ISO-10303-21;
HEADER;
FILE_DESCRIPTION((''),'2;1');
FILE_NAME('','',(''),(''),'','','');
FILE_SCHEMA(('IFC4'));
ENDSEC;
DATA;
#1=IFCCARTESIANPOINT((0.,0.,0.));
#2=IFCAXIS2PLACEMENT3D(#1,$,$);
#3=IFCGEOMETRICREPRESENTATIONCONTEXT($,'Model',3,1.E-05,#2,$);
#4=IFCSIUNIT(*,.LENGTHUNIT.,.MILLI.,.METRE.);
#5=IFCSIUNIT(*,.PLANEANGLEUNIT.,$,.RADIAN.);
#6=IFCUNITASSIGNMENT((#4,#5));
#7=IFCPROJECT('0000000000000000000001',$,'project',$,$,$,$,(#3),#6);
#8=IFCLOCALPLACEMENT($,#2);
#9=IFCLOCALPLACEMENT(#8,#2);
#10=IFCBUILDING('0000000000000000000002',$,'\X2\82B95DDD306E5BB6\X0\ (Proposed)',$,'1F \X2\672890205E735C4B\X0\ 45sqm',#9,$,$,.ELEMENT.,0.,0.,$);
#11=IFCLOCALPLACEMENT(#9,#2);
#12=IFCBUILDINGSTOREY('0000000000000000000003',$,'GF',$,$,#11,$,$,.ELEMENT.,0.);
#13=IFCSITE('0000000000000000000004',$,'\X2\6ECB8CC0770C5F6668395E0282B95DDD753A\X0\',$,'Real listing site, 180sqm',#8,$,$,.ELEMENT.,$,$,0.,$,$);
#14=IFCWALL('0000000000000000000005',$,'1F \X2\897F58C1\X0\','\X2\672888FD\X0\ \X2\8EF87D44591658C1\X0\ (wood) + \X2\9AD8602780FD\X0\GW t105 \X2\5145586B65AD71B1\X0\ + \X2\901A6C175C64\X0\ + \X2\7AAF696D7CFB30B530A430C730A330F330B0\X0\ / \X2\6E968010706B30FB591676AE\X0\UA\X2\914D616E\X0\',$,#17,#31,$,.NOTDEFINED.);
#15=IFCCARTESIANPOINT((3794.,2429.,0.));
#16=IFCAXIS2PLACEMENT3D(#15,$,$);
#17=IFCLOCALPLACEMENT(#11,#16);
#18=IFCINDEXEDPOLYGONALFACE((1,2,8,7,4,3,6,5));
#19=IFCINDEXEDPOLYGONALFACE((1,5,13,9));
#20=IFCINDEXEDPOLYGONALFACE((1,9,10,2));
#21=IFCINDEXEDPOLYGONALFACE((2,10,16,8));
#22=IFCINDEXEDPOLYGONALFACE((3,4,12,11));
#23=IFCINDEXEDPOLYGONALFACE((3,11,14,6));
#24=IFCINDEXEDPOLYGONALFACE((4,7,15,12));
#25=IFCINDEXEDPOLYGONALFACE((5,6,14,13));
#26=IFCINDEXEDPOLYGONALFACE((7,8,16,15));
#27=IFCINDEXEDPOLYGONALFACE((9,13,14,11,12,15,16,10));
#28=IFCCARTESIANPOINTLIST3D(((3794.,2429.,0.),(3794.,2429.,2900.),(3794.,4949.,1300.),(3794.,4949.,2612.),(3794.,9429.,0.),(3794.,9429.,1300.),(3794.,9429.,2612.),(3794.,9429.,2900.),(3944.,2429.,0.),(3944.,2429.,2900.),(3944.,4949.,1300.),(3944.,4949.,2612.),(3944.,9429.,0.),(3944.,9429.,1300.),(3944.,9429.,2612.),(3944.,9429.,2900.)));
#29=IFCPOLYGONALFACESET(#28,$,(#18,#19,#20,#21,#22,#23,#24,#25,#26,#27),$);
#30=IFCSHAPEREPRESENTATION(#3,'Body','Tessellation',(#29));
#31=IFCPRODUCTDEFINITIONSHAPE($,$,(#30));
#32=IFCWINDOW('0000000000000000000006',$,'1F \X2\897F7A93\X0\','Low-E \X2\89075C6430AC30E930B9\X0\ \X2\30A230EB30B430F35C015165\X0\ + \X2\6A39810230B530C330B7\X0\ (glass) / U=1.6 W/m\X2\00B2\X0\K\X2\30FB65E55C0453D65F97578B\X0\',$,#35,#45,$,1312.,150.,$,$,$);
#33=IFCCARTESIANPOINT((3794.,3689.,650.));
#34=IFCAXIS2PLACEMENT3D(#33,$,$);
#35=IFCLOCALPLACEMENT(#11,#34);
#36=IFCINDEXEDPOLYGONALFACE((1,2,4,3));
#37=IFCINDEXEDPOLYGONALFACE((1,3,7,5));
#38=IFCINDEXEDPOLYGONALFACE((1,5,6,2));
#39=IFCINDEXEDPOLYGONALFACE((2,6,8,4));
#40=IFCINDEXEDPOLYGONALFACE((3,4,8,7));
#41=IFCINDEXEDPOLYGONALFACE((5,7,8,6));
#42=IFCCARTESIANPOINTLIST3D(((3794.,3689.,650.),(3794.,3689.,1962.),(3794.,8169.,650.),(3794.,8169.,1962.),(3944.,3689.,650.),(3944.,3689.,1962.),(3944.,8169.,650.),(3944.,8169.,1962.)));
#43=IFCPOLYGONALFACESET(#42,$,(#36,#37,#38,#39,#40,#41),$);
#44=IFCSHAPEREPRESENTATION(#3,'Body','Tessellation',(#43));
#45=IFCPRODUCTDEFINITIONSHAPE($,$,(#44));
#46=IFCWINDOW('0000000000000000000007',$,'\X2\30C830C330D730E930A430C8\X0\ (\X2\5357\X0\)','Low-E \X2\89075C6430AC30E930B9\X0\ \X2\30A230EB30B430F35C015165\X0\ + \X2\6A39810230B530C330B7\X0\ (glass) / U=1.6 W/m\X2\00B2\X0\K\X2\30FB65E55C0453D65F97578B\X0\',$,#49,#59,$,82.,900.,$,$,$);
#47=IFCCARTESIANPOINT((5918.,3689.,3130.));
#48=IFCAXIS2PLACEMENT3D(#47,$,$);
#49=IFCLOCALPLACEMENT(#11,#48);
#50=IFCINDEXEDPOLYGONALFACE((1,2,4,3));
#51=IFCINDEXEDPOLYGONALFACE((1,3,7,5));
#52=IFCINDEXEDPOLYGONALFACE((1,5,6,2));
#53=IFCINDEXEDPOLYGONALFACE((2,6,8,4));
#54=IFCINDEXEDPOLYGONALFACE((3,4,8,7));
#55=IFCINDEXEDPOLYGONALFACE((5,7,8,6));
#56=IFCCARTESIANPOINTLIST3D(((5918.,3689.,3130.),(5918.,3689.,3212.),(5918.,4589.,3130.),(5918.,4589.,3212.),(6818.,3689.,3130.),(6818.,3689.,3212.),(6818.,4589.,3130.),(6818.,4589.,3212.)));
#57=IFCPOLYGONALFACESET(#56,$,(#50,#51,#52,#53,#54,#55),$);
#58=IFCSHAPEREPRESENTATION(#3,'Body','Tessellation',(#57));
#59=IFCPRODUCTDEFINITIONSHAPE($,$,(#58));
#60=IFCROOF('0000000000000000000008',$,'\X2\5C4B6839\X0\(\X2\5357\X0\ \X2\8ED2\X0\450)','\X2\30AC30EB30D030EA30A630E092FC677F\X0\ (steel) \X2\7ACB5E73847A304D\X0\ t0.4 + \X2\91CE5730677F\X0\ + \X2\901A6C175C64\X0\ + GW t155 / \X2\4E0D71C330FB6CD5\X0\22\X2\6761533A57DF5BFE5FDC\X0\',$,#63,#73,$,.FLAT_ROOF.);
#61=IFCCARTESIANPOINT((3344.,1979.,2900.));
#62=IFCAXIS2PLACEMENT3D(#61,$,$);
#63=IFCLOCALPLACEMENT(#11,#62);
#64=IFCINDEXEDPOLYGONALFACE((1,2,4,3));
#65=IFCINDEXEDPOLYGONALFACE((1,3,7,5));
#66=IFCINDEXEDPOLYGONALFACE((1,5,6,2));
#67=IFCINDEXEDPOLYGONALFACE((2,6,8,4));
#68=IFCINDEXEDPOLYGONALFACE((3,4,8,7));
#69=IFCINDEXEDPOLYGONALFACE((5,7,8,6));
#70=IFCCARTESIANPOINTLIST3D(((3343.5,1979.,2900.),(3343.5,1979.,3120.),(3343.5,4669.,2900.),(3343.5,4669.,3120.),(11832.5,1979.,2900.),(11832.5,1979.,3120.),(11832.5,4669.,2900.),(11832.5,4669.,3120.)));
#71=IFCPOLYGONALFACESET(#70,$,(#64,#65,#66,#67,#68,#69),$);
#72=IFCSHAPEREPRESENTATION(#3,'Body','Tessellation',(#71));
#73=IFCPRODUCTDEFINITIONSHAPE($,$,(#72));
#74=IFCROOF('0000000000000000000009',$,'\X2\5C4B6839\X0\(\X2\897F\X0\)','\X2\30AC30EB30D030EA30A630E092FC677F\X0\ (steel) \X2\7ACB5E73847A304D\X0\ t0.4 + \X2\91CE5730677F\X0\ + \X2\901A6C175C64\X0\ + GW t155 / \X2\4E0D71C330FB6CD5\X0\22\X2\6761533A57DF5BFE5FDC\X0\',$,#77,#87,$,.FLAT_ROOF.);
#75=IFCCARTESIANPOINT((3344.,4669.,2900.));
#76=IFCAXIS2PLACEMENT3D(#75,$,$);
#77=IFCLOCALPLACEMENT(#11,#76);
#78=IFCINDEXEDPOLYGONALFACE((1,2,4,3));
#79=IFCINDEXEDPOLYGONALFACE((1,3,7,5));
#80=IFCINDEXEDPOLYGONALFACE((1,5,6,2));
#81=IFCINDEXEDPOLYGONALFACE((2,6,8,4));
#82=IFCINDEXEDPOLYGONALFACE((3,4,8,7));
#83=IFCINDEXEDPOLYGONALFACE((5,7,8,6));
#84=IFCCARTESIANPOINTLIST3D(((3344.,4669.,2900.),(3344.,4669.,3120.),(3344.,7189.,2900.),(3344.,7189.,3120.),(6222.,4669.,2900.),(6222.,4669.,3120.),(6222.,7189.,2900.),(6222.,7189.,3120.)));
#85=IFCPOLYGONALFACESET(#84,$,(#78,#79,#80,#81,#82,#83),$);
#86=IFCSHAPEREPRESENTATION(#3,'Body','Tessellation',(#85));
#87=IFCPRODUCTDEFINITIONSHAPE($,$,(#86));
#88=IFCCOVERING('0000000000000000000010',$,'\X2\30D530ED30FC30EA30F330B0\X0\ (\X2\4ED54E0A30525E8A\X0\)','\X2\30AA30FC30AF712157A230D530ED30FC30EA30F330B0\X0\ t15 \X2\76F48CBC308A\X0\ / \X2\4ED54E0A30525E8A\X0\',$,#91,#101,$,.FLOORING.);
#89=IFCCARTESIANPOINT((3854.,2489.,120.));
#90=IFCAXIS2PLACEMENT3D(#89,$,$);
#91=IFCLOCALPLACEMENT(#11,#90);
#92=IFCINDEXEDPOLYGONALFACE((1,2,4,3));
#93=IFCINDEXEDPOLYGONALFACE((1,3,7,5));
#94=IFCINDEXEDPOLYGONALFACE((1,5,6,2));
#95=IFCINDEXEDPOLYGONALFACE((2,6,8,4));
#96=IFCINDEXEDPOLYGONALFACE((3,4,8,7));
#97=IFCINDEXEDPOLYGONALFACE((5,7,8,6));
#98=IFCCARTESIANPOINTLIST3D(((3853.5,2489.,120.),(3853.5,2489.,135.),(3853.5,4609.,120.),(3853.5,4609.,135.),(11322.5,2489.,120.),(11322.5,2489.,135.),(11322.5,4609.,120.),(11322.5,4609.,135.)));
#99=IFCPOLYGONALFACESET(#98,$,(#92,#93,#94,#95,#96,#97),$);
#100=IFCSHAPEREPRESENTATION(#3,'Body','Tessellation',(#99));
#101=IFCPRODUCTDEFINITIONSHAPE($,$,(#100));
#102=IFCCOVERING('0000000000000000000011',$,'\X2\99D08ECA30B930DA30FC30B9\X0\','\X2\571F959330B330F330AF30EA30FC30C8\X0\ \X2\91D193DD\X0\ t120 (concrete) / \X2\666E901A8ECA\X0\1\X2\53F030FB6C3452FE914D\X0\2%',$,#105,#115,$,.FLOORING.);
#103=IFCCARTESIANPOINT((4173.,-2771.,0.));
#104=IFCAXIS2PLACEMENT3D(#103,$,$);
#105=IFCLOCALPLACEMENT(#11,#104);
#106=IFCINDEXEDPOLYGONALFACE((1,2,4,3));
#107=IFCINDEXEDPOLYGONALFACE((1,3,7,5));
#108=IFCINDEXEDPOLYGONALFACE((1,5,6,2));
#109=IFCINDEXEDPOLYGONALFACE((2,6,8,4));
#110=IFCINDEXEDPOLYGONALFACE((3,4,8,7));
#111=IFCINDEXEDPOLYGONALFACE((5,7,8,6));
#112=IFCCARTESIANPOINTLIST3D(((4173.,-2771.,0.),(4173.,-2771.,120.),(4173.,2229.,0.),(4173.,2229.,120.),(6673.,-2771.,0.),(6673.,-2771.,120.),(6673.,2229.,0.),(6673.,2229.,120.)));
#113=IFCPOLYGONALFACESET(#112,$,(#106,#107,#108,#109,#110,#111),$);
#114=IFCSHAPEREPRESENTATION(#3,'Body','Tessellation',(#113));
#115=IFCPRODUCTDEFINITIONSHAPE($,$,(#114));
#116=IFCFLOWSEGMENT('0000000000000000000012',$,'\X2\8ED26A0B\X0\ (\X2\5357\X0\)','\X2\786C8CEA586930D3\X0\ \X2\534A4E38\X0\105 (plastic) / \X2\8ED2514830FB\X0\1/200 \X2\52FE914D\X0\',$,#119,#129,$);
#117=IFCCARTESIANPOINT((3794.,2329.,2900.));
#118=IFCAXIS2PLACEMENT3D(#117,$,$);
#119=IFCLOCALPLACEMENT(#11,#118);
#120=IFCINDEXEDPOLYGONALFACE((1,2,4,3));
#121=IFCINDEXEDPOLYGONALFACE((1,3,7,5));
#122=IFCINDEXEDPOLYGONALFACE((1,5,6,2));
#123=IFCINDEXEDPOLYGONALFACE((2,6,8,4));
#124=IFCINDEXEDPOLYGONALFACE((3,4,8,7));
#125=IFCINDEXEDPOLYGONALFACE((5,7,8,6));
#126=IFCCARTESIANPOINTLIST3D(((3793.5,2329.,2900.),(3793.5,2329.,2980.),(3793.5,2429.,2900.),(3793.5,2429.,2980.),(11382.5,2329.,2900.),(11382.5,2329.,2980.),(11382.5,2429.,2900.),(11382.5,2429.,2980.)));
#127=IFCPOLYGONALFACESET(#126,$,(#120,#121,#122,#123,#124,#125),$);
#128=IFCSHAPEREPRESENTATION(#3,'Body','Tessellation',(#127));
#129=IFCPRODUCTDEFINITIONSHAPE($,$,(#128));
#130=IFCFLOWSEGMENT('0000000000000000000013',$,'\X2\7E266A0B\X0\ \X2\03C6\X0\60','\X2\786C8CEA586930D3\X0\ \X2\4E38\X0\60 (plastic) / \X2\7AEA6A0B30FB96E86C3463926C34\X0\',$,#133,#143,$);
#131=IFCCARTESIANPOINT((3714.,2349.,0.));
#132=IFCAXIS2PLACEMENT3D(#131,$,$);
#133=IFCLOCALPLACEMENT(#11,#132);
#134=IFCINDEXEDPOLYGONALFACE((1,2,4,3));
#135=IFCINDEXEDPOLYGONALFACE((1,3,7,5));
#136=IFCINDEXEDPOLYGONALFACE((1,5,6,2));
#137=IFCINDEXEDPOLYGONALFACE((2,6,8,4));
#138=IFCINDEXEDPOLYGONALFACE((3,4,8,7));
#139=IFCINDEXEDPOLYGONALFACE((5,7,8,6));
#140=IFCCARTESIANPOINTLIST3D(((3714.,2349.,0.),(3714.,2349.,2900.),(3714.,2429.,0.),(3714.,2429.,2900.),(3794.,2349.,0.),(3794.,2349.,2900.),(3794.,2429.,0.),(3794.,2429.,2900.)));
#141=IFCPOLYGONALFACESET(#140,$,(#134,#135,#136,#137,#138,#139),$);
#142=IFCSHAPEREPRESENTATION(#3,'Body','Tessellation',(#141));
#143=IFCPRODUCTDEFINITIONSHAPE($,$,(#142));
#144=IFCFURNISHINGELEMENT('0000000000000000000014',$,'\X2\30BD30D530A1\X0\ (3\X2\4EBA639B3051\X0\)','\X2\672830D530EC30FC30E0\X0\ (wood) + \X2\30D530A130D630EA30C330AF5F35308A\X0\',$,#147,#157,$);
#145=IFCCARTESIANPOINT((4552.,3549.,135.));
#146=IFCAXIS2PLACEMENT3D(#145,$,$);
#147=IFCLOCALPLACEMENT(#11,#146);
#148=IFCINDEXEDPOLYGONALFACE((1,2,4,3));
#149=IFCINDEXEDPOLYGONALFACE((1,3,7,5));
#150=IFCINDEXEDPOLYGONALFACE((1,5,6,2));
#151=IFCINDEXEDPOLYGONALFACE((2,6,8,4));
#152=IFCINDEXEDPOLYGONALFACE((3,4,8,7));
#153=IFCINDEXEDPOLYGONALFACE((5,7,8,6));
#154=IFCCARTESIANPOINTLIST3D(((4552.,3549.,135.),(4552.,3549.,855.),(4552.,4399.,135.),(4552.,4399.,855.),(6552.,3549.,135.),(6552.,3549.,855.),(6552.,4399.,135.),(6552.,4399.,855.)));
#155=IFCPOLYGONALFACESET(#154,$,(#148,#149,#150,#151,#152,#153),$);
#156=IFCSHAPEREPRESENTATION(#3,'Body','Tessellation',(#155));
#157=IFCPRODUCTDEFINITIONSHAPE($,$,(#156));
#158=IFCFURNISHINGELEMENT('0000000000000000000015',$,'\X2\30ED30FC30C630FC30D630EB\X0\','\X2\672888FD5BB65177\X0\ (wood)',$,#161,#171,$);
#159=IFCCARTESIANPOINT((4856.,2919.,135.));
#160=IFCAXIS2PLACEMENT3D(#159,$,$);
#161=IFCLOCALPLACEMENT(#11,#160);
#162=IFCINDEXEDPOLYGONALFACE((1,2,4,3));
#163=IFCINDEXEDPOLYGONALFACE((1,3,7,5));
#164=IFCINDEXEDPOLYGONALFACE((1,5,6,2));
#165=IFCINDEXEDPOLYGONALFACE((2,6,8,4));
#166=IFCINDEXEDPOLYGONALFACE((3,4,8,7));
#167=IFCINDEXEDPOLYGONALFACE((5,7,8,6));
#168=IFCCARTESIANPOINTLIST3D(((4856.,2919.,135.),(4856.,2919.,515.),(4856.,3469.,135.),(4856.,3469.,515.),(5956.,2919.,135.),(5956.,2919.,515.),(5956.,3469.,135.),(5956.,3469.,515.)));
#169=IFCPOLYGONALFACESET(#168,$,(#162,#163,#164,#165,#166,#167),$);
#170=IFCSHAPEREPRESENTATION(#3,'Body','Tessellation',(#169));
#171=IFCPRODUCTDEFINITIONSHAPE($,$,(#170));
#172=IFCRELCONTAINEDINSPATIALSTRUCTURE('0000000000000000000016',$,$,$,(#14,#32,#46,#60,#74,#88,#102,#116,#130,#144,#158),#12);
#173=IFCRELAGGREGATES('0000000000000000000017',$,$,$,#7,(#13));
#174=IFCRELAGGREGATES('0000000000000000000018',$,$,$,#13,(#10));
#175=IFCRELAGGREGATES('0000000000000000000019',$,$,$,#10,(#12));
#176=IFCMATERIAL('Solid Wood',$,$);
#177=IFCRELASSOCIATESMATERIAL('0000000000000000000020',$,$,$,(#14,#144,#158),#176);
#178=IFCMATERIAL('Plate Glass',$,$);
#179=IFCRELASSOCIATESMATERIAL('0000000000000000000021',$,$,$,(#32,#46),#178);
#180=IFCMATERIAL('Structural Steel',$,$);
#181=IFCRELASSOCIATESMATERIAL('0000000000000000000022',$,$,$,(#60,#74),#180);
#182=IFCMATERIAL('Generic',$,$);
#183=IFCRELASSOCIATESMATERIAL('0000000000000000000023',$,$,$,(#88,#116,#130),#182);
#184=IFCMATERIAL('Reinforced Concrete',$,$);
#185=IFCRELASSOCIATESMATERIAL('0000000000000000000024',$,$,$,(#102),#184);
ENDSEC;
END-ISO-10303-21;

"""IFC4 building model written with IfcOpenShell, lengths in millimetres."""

from ifc_helpers import new_model, si_unit, frame, frame_2d, origin, place, context, project, spatial, rectangle, extrude, material, element, fill, save


model = new_model("IFC4")

# Units and contexts
model_context = context("Model", 3, precision=1e-05, world=origin())
ifc_project = project(units=[si_unit("LENGTHUNIT", "METRE", prefix="MILLI"), si_unit("PLANEANGLEUNIT", "RADIAN")], contexts=[model_context])

# Site, building, storey
site_placement = place(None, origin())
site = spatial("IfcSite", under=ifc_project, at=site_placement, Name="滋賀県彦根市芹川町", ObjectType="Real listing site, 180sqm", CompositionType="ELEMENT", RefElevation=0.0)
building_placement = place(site_placement, origin())
building = spatial("IfcBuilding", under=site, at=building_placement, Name="芹川の家 (Proposed)", ObjectType="1F 木造平屋 45sqm", CompositionType="ELEMENT", ElevationOfRefHeight=0.0, ElevationOfTerrain=0.0)
storey_placement = place(building_placement, origin())
storey = spatial("IfcBuildingStorey", under=building, at=storey_placement, Name="GF", CompositionType="ELEMENT", Elevation=0.0)

# Shared definitions
ifc_material_1 = material(Name="Solid Wood")

# Shared definitions
ifc_material_2 = material(Name="Reinforced Concrete")

# Shared definitions
ifc_material_3 = material(Name="Plate Glass")

# Wall, opening, window
wall_1_placement = place(storey_placement, frame((3794.0, 2429.0, 0.0)))
wall_1 = element("IfcWall", 1, at=wall_1_placement, inside=storey, material=ifc_material_1, Name="1F 西壁", Description="木製 軸組外壁 (wood) + 高性能GW t105 充填断熱 + 通気層 + 窯業系サイディング / 準耐火・外皮UA配慮", PredefinedType="NOTDEFINED", context=model_context, shape_type="SweptSolid", body=[
    extrude(rectangle(XDim=150.0, YDim=7000.0, at=frame_2d((75.0, 3500.0))), frame((3794.0, 2429.0, 0.0)), (0.0, 0.0, 1.0), 2900.0),
])
opening_1_placement = place(storey_placement, frame((3794.0, 3689.0, 650.0)))
opening_1 = element("IfcOpeningElement", 2, at=opening_1_placement, cuts=wall_1, PredefinedType="NOTDEFINED", context=model_context, shape_type="SweptSolid", body=[
    extrude(rectangle(XDim=150.0, YDim=4480.0, at=frame_2d((75.0, 2240.0))), frame((3794.0, 3689.0, 650.0)), (0.0, 0.0, 1.0), 1312.0),
])
window_1_placement = place(storey_placement, frame((3794.0, 3689.0, 650.0)))
window_1 = element("IfcWindow", 3, at=window_1_placement, inside=storey, material=ifc_material_3, Name="1F 西窓", Description="Low-E 複層ガラス アルゴン封入 + 樹脂サッシ (glass) / U=1.6 W/m²K・日射取得型", OverallHeight=1312.0, OverallWidth=150.0, context=model_context, shape_type="SweptSolid", body=[
    extrude(rectangle(XDim=150.0, YDim=4480.0, at=frame_2d((75.0, 2240.0))), frame((3794.0, 3689.0, 650.0)), (0.0, 0.0, 1.0), 1312.0),
])
fill(opening_1, window_1)

# Window
window_2_placement = place(storey_placement, frame((5918.0, 3689.0, 3130.0)))
element("IfcWindow", 4, at=window_2_placement, inside=storey, material=ifc_material_3, Name="トップライト (南)", Description="Low-E 複層ガラス アルゴン封入 + 樹脂サッシ (glass) / U=1.6 W/m²K・日射取得型", OverallHeight=82.0, OverallWidth=900.0, context=model_context, shape_type="SweptSolid", body=[
    extrude(rectangle(XDim=900.0, YDim=900.0, at=frame_2d((450.0, 450.0))), frame((5918.0, 3689.0, 3130.0)), (0.0, 0.0, 1.0), 82.0),
])

# Roofs
ifc_material_4 = material(Name="Structural Steel")
roof_1_placement = place(storey_placement, frame((3344.0, 1979.0, 2900.0)))
element("IfcRoof", 5, at=roof_1_placement, inside=storey, material=ifc_material_4, Name="屋根(南 軒450)", Description="ガルバリウム鋼板 (steel) 立平葺き t0.4 + 野地板 + 通気層 + GW t155 / 不燃・法22条区域対応", PredefinedType="FLAT_ROOF", context=model_context, shape_type="SweptSolid", body=[
    extrude(rectangle(XDim=8489.0, YDim=2690.0, at=frame_2d((4244.0, 1345.0))), frame((3344.0, 1979.0, 2900.0)), (0.0, 0.0, 1.0), 220.0),
])
roof_2_placement = place(storey_placement, frame((3344.0, 4669.0, 2900.0)))
element("IfcRoof", 6, at=roof_2_placement, inside=storey, material=ifc_material_4, Name="屋根(西)", Description="ガルバリウム鋼板 (steel) 立平葺き t0.4 + 野地板 + 通気層 + GW t155 / 不燃・法22条区域対応", PredefinedType="FLAT_ROOF", context=model_context, shape_type="SweptSolid", body=[
    extrude(rectangle(XDim=2878.0, YDim=2520.0, at=frame_2d((1439.0, 1260.0))), frame((3344.0, 4669.0, 2900.0)), (0.0, 0.0, 1.0), 220.0),
])

# Coverings
ifc_material_5 = material(Name="Generic")
covering_1_placement = place(storey_placement, frame((3854.0, 2489.0, 120.0)))
element("IfcCovering", 7, at=covering_1_placement, inside=storey, material=ifc_material_5, Name="フローリング (仕上げ床)", Description="オーク無垢フローリング t15 直貼り / 仕上げ床", PredefinedType="FLOORING", context=model_context, shape_type="SweptSolid", body=[
    extrude(rectangle(XDim=7469.0, YDim=2120.0, at=frame_2d((3734.0, 1060.0))), frame((3854.0, 2489.0, 120.0)), (0.0, 0.0, 1.0), 15.0),
])
covering_2_placement = place(storey_placement, frame((4173.0, -2771.0, 0.0)))
element("IfcCovering", 8, at=covering_2_placement, inside=storey, material=ifc_material_2, Name="駐車スペース", Description="土間コンクリート 金鏝 t120 (concrete) / 普通車1台・水勾配2%", PredefinedType="FLOORING", context=model_context, shape_type="SweptSolid", body=[
    extrude(rectangle(XDim=2500.0, YDim=5000.0, at=frame_2d((1250.0, 2500.0))), frame((4173.0, -2771.0, 0.0)), (0.0, 0.0, 1.0), 120.0),
])

# Flow segments
flow_segment_1_placement = place(storey_placement, frame((3794.0, 2329.0, 2900.0)))
element("IfcFlowSegment", 9, at=flow_segment_1_placement, inside=storey, material=ifc_material_5, Name="軒樋 (南)", Description="硬質塩ビ 半丸105 (plastic) / 軒先・1/200 勾配", context=model_context, shape_type="SweptSolid", body=[
    extrude(rectangle(XDim=7589.0, YDim=100.0, at=frame_2d((3794.0, 50.0))), frame((3794.0, 2329.0, 2900.0)), (0.0, 0.0, 1.0), 80.0),
])
flow_segment_2_placement = place(storey_placement, frame((3714.0, 2349.0, 0.0)))
element("IfcFlowSegment", 10, at=flow_segment_2_placement, inside=storey, material=ifc_material_5, Name="縦樋 φ60", Description="硬質塩ビ 丸60 (plastic) / 竪樋・雨水排水", context=model_context, shape_type="SweptSolid", body=[
    extrude(rectangle(XDim=80.0, YDim=80.0, at=frame_2d((40.0, 40.0))), frame((3714.0, 2349.0, 0.0)), (0.0, 0.0, 1.0), 2900.0),
])

# Furnishing elements
furnishing_1_placement = place(storey_placement, frame((4552.0, 3549.0, 135.0)))
element("IfcFurnishingElement", 11, at=furnishing_1_placement, inside=storey, material=ifc_material_1, Name="ソファ (3人掛け)", Description="木フレーム (wood) + ファブリック張り", context=model_context, shape_type="SweptSolid", body=[
    extrude(rectangle(XDim=2000.0, YDim=850.0, at=frame_2d((1000.0, 425.0))), frame((4552.0, 3549.0, 135.0)), (0.0, 0.0, 1.0), 720.0),
])
furnishing_2_placement = place(storey_placement, frame((4856.0, 2919.0, 135.0)))
element("IfcFurnishingElement", 12, at=furnishing_2_placement, inside=storey, material=ifc_material_1, Name="ローテーブル", Description="木製家具 (wood)", context=model_context, shape_type="SweptSolid", body=[
    extrude(rectangle(XDim=1100.0, YDim=550.0, at=frame_2d((550.0, 275.0))), frame((4856.0, 2919.0, 135.0)), (0.0, 0.0, 1.0), 380.0),
])

save(model, "model.ifc")
